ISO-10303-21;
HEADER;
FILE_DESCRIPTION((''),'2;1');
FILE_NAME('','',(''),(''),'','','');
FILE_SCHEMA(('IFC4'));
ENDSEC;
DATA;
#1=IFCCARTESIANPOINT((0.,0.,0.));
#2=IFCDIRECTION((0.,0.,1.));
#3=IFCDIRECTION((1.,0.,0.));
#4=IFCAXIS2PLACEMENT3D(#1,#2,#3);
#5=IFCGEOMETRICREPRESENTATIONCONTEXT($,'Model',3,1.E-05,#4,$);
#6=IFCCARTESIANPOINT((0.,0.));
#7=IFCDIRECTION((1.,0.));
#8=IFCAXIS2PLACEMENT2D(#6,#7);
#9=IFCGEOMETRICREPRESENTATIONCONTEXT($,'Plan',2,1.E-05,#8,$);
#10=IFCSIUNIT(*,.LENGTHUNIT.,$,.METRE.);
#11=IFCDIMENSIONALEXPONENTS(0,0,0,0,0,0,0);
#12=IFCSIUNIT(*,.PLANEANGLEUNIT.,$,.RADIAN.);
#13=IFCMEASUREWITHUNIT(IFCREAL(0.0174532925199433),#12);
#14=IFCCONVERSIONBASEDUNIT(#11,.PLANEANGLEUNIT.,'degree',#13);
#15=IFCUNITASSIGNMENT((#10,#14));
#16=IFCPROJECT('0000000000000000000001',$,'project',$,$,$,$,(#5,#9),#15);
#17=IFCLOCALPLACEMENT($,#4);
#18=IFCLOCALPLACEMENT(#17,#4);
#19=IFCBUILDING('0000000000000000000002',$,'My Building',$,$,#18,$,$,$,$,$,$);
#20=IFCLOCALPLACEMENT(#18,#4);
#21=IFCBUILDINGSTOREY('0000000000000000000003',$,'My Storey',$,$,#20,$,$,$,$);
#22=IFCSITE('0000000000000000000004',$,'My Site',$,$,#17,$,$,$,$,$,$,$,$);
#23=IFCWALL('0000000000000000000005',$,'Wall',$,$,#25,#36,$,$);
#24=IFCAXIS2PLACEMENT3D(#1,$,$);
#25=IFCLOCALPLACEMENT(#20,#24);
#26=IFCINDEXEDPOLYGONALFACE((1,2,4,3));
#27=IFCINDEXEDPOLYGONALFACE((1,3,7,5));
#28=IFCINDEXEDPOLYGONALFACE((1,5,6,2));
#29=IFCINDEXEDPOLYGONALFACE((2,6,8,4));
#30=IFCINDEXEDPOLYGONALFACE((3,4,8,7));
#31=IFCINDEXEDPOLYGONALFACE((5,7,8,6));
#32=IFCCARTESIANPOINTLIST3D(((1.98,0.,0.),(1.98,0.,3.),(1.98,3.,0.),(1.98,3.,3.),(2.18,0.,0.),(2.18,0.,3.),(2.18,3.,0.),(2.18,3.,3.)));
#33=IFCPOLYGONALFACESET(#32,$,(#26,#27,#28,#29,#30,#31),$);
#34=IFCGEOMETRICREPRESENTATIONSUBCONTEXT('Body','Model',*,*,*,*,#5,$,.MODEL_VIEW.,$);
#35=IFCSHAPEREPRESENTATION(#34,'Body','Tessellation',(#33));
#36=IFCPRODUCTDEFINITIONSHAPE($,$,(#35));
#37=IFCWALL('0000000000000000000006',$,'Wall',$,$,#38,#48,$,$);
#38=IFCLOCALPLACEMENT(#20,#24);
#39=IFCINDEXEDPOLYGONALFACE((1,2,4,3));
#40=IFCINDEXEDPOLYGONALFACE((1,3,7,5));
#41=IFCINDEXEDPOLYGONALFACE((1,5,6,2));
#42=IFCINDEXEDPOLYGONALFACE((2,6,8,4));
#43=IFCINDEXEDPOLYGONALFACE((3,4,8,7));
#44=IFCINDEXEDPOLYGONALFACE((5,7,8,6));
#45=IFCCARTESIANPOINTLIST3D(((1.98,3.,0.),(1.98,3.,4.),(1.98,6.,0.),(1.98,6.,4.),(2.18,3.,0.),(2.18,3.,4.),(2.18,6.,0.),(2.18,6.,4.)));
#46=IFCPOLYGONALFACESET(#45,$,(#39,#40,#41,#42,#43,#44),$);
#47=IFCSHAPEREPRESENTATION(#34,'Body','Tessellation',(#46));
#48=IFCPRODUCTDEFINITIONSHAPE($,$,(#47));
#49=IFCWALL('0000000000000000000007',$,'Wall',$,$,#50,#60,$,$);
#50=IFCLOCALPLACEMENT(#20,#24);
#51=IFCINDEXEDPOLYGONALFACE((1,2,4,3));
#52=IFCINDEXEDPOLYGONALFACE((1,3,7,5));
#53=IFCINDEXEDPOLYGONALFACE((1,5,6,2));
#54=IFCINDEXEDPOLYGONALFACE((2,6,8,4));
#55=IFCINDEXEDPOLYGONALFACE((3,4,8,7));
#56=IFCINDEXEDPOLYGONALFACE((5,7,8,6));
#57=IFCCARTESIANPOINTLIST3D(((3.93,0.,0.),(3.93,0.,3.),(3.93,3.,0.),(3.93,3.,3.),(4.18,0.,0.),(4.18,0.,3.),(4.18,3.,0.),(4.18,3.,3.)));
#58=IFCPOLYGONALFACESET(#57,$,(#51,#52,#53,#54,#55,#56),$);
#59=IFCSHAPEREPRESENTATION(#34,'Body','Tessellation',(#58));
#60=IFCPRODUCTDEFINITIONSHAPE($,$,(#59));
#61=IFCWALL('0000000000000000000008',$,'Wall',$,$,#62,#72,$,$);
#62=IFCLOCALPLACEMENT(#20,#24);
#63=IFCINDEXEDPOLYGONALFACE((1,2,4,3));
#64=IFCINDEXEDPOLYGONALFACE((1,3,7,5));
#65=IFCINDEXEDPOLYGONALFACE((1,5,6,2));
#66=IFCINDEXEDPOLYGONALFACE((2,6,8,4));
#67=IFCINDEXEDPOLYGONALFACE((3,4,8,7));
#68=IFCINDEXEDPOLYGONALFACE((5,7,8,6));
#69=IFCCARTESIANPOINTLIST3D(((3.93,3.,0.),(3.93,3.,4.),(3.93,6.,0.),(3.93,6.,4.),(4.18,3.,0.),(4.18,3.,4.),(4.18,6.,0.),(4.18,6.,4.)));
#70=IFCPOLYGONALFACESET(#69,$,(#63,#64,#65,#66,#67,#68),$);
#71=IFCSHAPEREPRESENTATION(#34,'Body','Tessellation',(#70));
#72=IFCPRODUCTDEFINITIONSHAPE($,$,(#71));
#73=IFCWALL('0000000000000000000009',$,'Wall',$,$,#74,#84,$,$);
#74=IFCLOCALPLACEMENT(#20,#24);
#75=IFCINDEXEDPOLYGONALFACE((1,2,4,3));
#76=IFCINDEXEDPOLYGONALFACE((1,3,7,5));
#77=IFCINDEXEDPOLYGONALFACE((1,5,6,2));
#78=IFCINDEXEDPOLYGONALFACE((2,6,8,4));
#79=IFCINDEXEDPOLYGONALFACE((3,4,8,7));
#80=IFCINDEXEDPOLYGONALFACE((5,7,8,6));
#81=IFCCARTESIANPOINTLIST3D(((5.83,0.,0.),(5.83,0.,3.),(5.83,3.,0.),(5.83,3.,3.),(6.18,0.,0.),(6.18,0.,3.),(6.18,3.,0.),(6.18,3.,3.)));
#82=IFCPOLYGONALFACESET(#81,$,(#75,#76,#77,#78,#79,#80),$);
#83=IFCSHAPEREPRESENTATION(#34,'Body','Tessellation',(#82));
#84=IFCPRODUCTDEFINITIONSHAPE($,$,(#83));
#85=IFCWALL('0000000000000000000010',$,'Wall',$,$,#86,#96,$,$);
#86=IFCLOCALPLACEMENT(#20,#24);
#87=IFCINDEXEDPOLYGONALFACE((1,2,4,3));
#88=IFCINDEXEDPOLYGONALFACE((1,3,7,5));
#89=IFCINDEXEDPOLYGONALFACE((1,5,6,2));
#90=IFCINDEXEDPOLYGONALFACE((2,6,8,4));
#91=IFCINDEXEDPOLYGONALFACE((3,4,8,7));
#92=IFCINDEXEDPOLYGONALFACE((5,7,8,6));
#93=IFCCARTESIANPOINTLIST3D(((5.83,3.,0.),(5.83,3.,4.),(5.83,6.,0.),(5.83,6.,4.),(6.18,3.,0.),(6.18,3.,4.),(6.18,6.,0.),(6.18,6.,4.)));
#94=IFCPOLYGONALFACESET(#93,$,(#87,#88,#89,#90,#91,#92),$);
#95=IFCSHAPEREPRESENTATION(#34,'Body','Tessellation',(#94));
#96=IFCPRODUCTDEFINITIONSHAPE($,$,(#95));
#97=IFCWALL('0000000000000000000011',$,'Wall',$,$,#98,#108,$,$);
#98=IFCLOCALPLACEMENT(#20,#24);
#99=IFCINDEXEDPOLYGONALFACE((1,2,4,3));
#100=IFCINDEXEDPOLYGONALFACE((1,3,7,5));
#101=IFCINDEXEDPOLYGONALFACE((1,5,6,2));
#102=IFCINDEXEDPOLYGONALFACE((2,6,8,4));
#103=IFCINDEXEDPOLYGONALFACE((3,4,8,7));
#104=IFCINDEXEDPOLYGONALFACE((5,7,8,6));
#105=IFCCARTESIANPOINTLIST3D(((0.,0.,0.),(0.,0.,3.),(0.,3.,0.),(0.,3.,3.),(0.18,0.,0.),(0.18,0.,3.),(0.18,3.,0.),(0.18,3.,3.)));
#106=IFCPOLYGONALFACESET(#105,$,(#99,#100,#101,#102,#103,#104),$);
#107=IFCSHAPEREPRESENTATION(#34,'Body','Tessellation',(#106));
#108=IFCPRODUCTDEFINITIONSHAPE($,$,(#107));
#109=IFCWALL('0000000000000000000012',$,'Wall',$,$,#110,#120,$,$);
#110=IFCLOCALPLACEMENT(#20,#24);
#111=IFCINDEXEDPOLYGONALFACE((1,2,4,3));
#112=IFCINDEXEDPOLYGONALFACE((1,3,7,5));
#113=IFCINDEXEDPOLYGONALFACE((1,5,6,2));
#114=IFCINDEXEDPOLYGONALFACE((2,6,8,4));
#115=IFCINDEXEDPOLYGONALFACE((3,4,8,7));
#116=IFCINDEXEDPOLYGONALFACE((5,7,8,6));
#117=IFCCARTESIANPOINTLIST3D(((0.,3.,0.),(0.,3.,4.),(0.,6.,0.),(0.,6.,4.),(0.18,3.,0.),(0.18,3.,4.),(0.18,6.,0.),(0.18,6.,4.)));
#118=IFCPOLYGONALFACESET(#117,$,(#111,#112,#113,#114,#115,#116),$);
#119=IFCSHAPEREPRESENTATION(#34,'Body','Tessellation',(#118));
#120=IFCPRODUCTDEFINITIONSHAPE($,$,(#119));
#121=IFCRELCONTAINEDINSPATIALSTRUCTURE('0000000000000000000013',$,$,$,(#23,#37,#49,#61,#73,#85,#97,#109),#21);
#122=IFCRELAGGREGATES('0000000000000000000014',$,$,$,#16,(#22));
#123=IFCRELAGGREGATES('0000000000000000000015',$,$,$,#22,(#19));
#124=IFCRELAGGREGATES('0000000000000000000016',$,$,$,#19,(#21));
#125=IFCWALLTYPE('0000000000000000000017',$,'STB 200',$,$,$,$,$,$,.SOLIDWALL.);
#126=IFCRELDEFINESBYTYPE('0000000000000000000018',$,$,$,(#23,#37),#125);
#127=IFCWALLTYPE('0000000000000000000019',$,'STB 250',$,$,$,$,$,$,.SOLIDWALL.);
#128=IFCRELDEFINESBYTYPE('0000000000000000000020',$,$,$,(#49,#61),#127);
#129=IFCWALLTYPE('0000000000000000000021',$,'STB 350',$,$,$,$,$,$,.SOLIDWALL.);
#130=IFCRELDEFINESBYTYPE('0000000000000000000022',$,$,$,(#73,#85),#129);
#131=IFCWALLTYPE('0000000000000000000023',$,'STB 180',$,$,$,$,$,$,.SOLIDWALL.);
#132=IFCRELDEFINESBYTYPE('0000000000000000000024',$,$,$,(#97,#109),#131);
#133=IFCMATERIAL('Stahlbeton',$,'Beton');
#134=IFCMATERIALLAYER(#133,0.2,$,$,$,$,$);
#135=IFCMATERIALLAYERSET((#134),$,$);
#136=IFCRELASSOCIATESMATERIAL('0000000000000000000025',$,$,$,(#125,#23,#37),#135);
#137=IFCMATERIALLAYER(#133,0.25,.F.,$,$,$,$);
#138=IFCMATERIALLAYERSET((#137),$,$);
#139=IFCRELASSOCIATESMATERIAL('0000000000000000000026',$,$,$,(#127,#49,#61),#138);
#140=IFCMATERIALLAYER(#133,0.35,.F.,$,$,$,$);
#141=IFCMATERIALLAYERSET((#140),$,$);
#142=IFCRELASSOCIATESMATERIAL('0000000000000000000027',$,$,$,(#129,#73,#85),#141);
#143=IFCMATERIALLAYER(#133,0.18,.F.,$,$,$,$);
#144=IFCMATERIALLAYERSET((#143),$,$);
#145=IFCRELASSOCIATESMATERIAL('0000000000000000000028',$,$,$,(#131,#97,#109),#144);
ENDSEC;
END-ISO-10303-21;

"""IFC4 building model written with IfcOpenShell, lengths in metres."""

from ifc_helpers import new_model, entity, si_unit, converted_unit, frame, origin_with_axes, origin_2d_with_axis, place, context, subcontext, project, spatial, line, indexed_curve, outline, extrude, material, layer, layer_set, layer_usage, type_object, element, save


model = new_model("IFC4")

# Units and contexts
model_context = context("Model", 3, precision=1e-05, world=origin_with_axes())
plan_context = context("Plan", 2, precision=1e-05, world=origin_2d_with_axis())
body_context = subcontext(model_context, "Body", "Model", "MODEL_VIEW")
ifc_project = project(units=[si_unit("LENGTHUNIT", "METRE"), converted_unit("PLANEANGLEUNIT", "degree", entity("IfcReal", 0.0174532925199433), si_unit("PLANEANGLEUNIT", "RADIAN"), dimensions=[0, 0, 0, 0, 0, 0, 0])], contexts=[model_context, plan_context])

# Site, building, storey
site_placement = place(None, origin_with_axes())
site = spatial("IfcSite", under=ifc_project, at=site_placement, Name="My Site")
building_placement = place(site_placement, origin_with_axes())
building = spatial("IfcBuilding", under=site, at=building_placement, Name="My Building")
storey_placement = place(building_placement, origin_with_axes())
storey = spatial("IfcBuildingStorey", under=building, at=storey_placement, Name="My Storey")

# Walls
ifc_material = material(Name="Stahlbeton", Category="Beton")
ifc_layer_1 = layer(ifc_material, 0.2)
ifc_layer_set_1 = layer_set([ifc_layer_1])
ifc_layer_usage_1 = layer_usage(ifc_layer_set_1, "AXIS2", "POSITIVE", 0.0)
wall_type_1 = type_object("IfcWallType", Name="STB 200", PredefinedType="SOLIDWALL", material=ifc_layer_set_1)
wall_1_placement = place(storey_placement, frame((2.18, 0.0, 0.0), z_axis=(0.0, 0.0, 1.0), x_axis=(0.0, 1.0, 0.0)))
element("IfcWall", 1, at=wall_1_placement, inside=storey, type_object=wall_type_1, material=ifc_layer_usage_1, Name="Wall", context=body_context, shape_type="SweptSolid", body=[
    extrude(outline(indexed_curve([(0.0, 0.0), (0.0, 0.2), (3.0, 0.2), (3.0, 0.0)], segments=[line(1, 2, 3, 4, 1)])), origin_with_axes(), (0.0, 0.0, 1.0), 3.0),
])
ifc_layer_usage_2 = layer_usage(ifc_layer_set_1, "AXIS2", "POSITIVE", 0.0)
wall_2_placement = place(storey_placement, frame((2.18, 3.0, 0.0), z_axis=(0.0, 0.0, 1.0), x_axis=(0.0, 1.0, 0.0)))
element("IfcWall", 2, at=wall_2_placement, inside=storey, type_object=wall_type_1, material=ifc_layer_usage_2, Name="Wall", context=body_context, shape_type="SweptSolid", body=[
    extrude(outline(indexed_curve([(0.0, 0.0), (0.0, 0.2), (3.0, 0.2), (3.0, 0.0)], segments=[line(1, 2, 3, 4, 1)])), origin_with_axes(), (0.0, 0.0, 1.0), 4.0),
])
ifc_layer_2 = layer(ifc_material, 0.25, ventilated=False)
ifc_layer_set_2 = layer_set([ifc_layer_2])
ifc_layer_usage_3 = layer_usage(ifc_layer_set_2, "AXIS2", "POSITIVE", 0.0)
wall_type_2 = type_object("IfcWallType", Name="STB 250", PredefinedType="SOLIDWALL", material=ifc_layer_set_2)
wall_3_placement = place(storey_placement, frame((4.18, 0.0, 0.0), z_axis=(0.0, 0.0, 1.0), x_axis=(0.0, 1.0, 0.0)))
element("IfcWall", 3, at=wall_3_placement, inside=storey, type_object=wall_type_2, material=ifc_layer_usage_3, Name="Wall", context=body_context, shape_type="SweptSolid", body=[
    extrude(outline(indexed_curve([(0.0, 0.0), (0.0, 0.25), (3.0, 0.25), (3.0, 0.0)], segments=[line(1, 2, 3, 4, 1)])), origin_with_axes(), (0.0, 0.0, 1.0), 3.0),
])
ifc_layer_usage_4 = layer_usage(ifc_layer_set_2, "AXIS2", "POSITIVE", 0.0)
wall_4_placement = place(storey_placement, frame((4.18, 3.0, 0.0), z_axis=(0.0, 0.0, 1.0), x_axis=(0.0, 1.0, 0.0)))
element("IfcWall", 4, at=wall_4_placement, inside=storey, type_object=wall_type_2, material=ifc_layer_usage_4, Name="Wall", context=body_context, shape_type="SweptSolid", body=[
    extrude(outline(indexed_curve([(0.0, 0.0), (0.0, 0.25), (3.0, 0.25), (3.0, 0.0)], segments=[line(1, 2, 3, 4, 1)])), origin_with_axes(), (0.0, 0.0, 1.0), 4.0),
])
ifc_layer_3 = layer(ifc_material, 0.35, ventilated=False)
ifc_layer_set_3 = layer_set([ifc_layer_3])
ifc_layer_usage_5 = layer_usage(ifc_layer_set_3, "AXIS2", "POSITIVE", 0.0)
wall_type_3 = type_object("IfcWallType", Name="STB 350", PredefinedType="SOLIDWALL", material=ifc_layer_set_3)
wall_5_placement = place(storey_placement, frame((6.18, 0.0, 0.0), z_axis=(0.0, 0.0, 1.0), x_axis=(0.0, 1.0, 0.0)))
element("IfcWall", 5, at=wall_5_placement, inside=storey, type_object=wall_type_3, material=ifc_layer_usage_5, Name="Wall", context=body_context, shape_type="SweptSolid", body=[
    extrude(outline(indexed_curve([(0.0, 0.0), (0.0, 0.35), (3.0, 0.35), (3.0, 0.0)], segments=[line(1, 2, 3, 4, 1)])), origin_with_axes(), (0.0, 0.0, 1.0), 3.0),
])
ifc_layer_usage_6 = layer_usage(ifc_layer_set_3, "AXIS2", "POSITIVE", 0.0)
wall_6_placement = place(storey_placement, frame((6.18, 3.0, 0.0), z_axis=(0.0, 0.0, 1.0), x_axis=(0.0, 1.0, 0.0)))
element("IfcWall", 6, at=wall_6_placement, inside=storey, type_object=wall_type_3, material=ifc_layer_usage_6, Name="Wall", context=body_context, shape_type="SweptSolid", body=[
    extrude(outline(indexed_curve([(0.0, 0.0), (0.0, 0.35), (3.0, 0.35), (3.0, 0.0)], segments=[line(1, 2, 3, 4, 1)])), origin_with_axes(), (0.0, 0.0, 1.0), 4.0),
])
ifc_layer_4 = layer(ifc_material, 0.18, ventilated=False)
ifc_layer_set_4 = layer_set([ifc_layer_4])
ifc_layer_usage_7 = layer_usage(ifc_layer_set_4, "AXIS2", "POSITIVE", 0.0)
wall_type_4 = type_object("IfcWallType", Name="STB 180", PredefinedType="SOLIDWALL", material=ifc_layer_set_4)
wall_7_placement = place(storey_placement, frame((0.18, 0.0, 0.0), z_axis=(0.0, 0.0, 1.0), x_axis=(0.0, 1.0, 0.0)))
element("IfcWall", 7, at=wall_7_placement, inside=storey, type_object=wall_type_4, material=ifc_layer_usage_7, Name="Wall", context=body_context, shape_type="SweptSolid", body=[
    extrude(outline(indexed_curve([(0.0, 0.0), (0.0, 0.18), (3.0, 0.18), (3.0, 0.0)], segments=[line(1, 2, 3, 4, 1)])), origin_with_axes(), (0.0, 0.0, 1.0), 3.0),
])
ifc_layer_usage_8 = layer_usage(ifc_layer_set_4, "AXIS2", "POSITIVE", 0.0)
wall_8_placement = place(storey_placement, frame((0.18, 3.0, 0.0), z_axis=(0.0, 0.0, 1.0), x_axis=(0.0, 1.0, 0.0)))
element("IfcWall", 8, at=wall_8_placement, inside=storey, type_object=wall_type_4, material=ifc_layer_usage_8, Name="Wall", context=body_context, shape_type="SweptSolid", body=[
    extrude(outline(indexed_curve([(0.0, 0.0), (0.0, 0.18), (3.0, 0.18), (3.0, 0.0)], segments=[line(1, 2, 3, 4, 1)])), origin_with_axes(), (0.0, 0.0, 1.0), 4.0),
])

save(model, "model.ifc")
